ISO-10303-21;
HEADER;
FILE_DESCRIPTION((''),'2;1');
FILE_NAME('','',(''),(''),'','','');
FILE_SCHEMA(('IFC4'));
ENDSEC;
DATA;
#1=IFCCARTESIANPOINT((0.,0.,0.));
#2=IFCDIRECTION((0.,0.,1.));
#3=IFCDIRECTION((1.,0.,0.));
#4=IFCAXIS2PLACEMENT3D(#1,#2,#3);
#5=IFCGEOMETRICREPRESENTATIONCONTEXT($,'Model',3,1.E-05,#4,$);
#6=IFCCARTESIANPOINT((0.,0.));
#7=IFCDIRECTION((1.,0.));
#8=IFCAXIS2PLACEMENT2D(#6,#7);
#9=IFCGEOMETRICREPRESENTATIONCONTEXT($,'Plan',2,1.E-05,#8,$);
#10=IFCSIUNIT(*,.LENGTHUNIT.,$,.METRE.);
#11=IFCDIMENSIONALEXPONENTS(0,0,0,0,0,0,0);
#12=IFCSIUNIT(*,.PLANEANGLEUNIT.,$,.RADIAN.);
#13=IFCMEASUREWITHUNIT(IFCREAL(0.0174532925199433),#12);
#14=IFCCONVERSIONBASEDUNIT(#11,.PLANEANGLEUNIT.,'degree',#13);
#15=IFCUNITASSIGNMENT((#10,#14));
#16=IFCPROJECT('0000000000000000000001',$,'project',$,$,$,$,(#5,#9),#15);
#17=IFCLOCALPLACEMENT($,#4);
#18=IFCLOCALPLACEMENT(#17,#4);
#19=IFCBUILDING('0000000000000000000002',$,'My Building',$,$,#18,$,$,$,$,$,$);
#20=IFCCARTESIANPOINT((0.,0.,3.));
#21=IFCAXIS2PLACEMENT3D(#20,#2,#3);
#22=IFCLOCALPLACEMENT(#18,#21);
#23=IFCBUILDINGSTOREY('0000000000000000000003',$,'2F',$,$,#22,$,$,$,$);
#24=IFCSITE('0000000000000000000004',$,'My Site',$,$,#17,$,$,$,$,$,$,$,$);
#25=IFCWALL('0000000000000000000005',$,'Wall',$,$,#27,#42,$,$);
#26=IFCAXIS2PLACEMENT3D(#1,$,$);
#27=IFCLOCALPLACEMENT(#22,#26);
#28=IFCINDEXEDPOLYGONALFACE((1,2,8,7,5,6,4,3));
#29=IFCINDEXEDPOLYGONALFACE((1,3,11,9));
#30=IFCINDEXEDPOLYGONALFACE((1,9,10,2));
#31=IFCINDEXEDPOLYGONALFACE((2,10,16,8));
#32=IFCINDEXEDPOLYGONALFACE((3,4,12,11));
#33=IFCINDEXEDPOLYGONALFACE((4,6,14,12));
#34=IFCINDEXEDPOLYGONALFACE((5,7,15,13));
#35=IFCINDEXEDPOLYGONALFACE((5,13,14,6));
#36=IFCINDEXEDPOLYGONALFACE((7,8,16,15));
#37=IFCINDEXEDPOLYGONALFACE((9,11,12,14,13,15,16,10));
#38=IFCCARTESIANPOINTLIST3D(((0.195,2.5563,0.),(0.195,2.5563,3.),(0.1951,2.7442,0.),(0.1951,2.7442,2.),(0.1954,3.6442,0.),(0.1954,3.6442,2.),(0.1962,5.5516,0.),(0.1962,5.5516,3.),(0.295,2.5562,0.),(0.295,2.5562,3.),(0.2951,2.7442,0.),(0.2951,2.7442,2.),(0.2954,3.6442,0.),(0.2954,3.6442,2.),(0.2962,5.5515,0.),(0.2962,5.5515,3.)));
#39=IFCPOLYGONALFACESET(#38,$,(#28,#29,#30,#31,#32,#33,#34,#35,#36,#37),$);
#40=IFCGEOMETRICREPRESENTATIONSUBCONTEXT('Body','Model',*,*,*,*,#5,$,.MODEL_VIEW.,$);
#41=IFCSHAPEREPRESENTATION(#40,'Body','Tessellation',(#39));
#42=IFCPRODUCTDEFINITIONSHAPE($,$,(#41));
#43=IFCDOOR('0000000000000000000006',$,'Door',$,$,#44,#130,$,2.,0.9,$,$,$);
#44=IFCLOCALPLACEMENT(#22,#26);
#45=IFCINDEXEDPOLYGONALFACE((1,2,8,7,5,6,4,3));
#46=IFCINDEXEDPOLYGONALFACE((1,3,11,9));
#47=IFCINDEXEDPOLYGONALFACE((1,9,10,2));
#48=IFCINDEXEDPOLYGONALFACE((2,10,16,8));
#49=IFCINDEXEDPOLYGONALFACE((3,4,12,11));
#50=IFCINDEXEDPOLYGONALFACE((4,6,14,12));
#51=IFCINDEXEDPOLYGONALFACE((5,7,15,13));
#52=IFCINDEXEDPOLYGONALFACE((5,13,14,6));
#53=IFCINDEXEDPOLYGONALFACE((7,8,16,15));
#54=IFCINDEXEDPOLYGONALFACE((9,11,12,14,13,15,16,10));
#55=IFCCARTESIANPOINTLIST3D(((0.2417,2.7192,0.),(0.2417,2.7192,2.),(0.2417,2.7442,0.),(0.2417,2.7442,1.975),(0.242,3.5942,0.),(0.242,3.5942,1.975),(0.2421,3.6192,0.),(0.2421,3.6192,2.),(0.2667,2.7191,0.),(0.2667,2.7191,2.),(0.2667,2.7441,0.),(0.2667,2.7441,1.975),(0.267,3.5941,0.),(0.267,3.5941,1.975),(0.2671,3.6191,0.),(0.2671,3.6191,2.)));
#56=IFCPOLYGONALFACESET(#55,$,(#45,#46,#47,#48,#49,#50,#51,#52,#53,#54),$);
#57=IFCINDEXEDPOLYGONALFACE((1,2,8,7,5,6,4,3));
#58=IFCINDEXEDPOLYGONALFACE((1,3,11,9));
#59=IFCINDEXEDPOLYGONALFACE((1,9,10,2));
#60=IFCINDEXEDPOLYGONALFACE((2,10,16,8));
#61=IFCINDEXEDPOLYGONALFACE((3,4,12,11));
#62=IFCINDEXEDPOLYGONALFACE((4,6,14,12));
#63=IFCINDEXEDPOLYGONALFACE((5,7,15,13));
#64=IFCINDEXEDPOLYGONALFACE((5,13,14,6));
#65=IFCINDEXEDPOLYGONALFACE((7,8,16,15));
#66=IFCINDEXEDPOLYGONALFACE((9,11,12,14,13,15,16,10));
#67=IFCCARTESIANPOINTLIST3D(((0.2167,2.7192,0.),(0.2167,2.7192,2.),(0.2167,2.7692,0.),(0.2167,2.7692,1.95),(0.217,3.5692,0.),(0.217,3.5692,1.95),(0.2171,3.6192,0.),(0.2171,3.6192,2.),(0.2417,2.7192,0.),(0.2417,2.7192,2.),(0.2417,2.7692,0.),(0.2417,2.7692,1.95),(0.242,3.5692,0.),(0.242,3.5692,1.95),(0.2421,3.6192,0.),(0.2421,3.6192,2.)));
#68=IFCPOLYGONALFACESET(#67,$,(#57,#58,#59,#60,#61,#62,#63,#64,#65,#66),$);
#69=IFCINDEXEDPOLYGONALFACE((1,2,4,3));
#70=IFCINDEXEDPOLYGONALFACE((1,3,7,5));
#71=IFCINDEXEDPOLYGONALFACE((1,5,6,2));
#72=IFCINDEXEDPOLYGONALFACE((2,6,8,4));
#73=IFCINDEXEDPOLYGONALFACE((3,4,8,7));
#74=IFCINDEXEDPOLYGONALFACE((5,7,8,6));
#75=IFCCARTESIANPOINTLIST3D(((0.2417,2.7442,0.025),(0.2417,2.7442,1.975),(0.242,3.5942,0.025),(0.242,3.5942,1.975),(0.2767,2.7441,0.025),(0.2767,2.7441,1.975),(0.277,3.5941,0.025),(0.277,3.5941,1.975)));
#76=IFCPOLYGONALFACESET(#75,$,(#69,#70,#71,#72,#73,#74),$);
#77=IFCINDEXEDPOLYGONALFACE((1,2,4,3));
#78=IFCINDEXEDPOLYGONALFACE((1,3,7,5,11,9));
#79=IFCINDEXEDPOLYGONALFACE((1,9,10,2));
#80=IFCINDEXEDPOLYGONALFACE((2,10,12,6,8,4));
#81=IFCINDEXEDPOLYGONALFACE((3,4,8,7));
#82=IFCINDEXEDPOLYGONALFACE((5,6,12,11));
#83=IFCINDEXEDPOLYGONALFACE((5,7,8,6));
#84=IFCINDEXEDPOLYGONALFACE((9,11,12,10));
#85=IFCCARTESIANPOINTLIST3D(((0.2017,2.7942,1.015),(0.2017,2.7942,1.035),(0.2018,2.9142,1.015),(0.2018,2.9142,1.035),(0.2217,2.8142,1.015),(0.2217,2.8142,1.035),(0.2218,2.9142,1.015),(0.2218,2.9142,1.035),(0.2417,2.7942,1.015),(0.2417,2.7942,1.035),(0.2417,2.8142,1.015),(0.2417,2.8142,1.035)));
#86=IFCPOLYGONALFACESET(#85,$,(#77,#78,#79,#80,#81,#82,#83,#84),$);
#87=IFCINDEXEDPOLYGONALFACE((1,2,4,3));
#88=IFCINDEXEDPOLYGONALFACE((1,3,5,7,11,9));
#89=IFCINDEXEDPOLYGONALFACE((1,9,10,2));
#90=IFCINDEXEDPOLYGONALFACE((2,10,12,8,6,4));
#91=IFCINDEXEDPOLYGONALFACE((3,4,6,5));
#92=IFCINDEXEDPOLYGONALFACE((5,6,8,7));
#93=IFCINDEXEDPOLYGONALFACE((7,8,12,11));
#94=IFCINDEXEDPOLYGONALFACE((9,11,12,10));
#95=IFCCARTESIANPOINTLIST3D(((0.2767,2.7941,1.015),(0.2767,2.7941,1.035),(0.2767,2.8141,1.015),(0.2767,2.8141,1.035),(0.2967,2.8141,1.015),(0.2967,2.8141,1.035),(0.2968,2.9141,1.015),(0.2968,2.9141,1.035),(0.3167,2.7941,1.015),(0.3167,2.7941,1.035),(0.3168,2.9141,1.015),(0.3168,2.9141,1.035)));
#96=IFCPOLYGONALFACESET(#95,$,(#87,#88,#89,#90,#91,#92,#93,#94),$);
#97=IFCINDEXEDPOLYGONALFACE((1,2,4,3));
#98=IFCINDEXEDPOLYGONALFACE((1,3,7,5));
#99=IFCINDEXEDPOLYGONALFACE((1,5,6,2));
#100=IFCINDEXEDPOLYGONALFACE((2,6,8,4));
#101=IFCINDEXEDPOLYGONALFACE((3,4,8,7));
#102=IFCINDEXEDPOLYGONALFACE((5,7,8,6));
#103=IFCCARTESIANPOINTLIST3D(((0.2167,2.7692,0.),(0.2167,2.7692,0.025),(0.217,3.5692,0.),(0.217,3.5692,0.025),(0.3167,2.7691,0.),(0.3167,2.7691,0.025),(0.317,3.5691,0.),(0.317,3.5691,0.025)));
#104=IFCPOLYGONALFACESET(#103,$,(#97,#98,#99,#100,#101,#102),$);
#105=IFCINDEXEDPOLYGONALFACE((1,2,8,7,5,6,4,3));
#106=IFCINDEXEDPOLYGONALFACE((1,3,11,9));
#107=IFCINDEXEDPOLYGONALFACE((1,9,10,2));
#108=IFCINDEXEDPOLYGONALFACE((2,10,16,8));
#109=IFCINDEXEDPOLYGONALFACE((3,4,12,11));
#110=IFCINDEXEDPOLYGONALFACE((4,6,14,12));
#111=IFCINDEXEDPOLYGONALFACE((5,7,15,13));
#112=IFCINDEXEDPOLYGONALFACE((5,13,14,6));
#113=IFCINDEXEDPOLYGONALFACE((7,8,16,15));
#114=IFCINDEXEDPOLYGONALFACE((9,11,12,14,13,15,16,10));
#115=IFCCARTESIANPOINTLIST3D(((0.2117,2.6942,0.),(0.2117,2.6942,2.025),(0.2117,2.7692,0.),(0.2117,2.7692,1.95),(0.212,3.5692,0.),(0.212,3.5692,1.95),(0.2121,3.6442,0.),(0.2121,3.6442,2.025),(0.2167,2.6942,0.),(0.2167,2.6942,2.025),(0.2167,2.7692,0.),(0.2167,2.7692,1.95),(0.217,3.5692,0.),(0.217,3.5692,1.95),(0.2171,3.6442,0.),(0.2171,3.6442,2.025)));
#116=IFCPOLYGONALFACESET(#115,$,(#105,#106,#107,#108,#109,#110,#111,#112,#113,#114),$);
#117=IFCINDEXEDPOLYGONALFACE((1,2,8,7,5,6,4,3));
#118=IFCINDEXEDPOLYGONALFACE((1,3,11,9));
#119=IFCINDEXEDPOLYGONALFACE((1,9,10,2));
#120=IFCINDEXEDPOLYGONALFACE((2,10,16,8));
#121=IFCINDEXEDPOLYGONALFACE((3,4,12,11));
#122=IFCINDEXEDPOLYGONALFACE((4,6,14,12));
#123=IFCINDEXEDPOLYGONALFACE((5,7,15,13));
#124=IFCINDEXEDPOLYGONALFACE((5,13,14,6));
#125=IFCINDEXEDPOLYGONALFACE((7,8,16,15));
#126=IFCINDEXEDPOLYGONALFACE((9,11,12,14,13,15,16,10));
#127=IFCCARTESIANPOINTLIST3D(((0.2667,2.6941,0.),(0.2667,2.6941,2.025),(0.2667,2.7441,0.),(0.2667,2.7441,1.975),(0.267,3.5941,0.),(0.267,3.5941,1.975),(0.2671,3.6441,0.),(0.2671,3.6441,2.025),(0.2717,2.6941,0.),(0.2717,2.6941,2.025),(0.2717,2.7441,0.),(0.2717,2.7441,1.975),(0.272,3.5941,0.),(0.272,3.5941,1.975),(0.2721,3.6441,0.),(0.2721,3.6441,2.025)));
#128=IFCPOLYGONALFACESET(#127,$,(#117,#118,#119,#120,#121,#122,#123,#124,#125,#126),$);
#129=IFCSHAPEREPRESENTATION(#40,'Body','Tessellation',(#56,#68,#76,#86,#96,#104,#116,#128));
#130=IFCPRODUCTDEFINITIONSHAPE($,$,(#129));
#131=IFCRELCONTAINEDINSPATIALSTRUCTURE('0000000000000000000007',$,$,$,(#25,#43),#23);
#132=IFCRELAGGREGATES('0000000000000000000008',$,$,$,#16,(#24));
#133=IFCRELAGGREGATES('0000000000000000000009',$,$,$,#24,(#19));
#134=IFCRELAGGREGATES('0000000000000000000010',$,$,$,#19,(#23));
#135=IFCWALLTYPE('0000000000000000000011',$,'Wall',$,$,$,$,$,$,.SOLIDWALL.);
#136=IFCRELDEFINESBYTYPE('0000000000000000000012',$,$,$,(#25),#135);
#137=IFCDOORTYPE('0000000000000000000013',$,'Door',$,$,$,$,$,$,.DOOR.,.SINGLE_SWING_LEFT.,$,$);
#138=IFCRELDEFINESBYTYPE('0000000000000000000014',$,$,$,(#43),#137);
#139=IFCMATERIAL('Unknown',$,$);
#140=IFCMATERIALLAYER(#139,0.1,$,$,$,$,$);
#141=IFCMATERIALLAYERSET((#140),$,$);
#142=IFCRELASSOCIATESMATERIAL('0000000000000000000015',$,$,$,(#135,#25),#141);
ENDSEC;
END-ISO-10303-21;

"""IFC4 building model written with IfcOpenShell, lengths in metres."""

from ifc_helpers import new_model, entity, si_unit, converted_unit, frame, origin_with_axes, origin_2d_with_axis, place, context, subcontext, project, spatial, line, indexed_curve, outline, extrude, shape, source, transform, mapped, material, layer, layer_set, layer_usage, type_object, type_shapes, element, fill, save


model = new_model("IFC4")

# Units and contexts
model_context = context("Model", 3, precision=1e-05, world=origin_with_axes())
plan_context = context("Plan", 2, precision=1e-05, world=origin_2d_with_axis())
body_context_1 = subcontext(model_context, "Body", "Model", "MODEL_VIEW")
body_context_2 = subcontext(plan_context, "Body", "Plan", "PLAN_VIEW")
ifc_project = project(units=[si_unit("LENGTHUNIT", "METRE"), converted_unit("PLANEANGLEUNIT", "degree", entity("IfcReal", 0.0174532925199433), si_unit("PLANEANGLEUNIT", "RADIAN"), dimensions=[0, 0, 0, 0, 0, 0, 0])], contexts=[model_context, plan_context])

# Site, building, storey
site_placement = place(None, origin_with_axes())
site = spatial("IfcSite", under=ifc_project, at=site_placement, Name="My Site")
building_placement = place(site_placement, origin_with_axes())
building = spatial("IfcBuilding", under=site, at=building_placement, Name="My Building")
storey_placement = place(building_placement, frame((0.0, 0.0, 3.0), z_axis=(0.0, 0.0, 1.0), x_axis=(1.0, 0.0, 0.0)))
storey = spatial("IfcBuildingStorey", under=building, at=storey_placement, Name="2F")

# Shared definitions
ifc_material = material(Name="Unknown")

# Shared definitions
ifc_layer_1 = layer(ifc_material, 0.1)
ifc_layer_set_1 = layer_set([ifc_layer_1])
wall_type = type_object("IfcWallType", Name="Wall", PredefinedType="SOLIDWALL", material=ifc_layer_set_1)

# Wall, opening, door
ifc_layer_usage_1 = layer_usage(ifc_layer_set_1, "AXIS2", "POSITIVE", 0.0)
wall_1_placement = place(storey_placement, frame((0.1962, 5.5516, 0.0), z_axis=(0.0, 0.0, 1.0), x_axis=(-0.000399, -1.0, 0.0)))
wall_1 = element("IfcWall", 1, at=wall_1_placement, inside=storey, type_object=wall_type, material=ifc_layer_usage_1, Name="Wall", context=body_context_1, shape_type="SweptSolid", body=[
    extrude(outline(indexed_curve([(0.0, 0.0), (0.0, 0.1), (2.9953, 0.1), (2.9953, 0.0)], segments=[line(1, 2, 3, 4, 1)])), origin_with_axes(), (0.0, 0.0, 1.0), 3.0),
])
shared_shape_1 = source(origin_with_axes(), body_context_1, "Body", "SweptSolid", [
    extrude(outline(indexed_curve([(0.0, 0.0), (0.9, 0.0), (0.9, 2.0), (0.0, 2.0)], segments=[line(1, 2, 3, 4, 1)])), frame((0.0, -0.6, 0.0), z_axis=(0.0, -1.0, 0.0), x_axis=(1.0, 0.0, 0.0)), (0.0, 0.0, -1.0), 1.2),
])
opening_1_placement = place(wall_1_placement, frame((1.9074, 0.0, 0.0), z_axis=(0.0, 0.0, 1.0), x_axis=(1.0, 0.0, 0.0)))
opening_1 = element("IfcOpeningElement", 2, at=opening_1_placement, cuts=wall_1, PredefinedType="OPENING", context=body_context_1, shape_type="MappedRepresentation", body=[
    mapped(shared_shape_1, transform((0.0, 0.0, 0.0), x_axis=(1.0, 0.0, 0.0), y_axis=(0.0, 1.0, 0.0), z_axis=(0.0, 0.0, 1.0), scale=1.0)),
])
door_type_1 = type_object("IfcDoorType", Name="Door", OperationType="SINGLE_SWING_LEFT", PredefinedType="DOOR")
shared_shape_2 = source(origin_with_axes(), body_context_1, "Body", "SweptSolid", [
    extrude(outline(indexed_curve([(0.0, 0.0), (0.0, 2.0), (0.9, 2.0), (0.9, 0.0), (0.875, 0.0), (0.875, 1.975), (0.025, 1.975), (0.025, 0.0)], segments=[line(1, 2, 3, 4, 5, 6, 7, 8, 1)])), frame((0.0, 0.025, 0.0), z_axis=(0.0, -1.0, 0.0), x_axis=(1.0, 0.0, 0.0)), (0.0, 0.0, -1.0), 0.025),
    extrude(outline(indexed_curve([(0.0, 0.0), (0.0, 2.0), (0.9, 2.0), (0.9, 0.0), (0.85, 0.0), (0.85, 1.95), (0.05, 1.95), (0.05, 0.0)], segments=[line(1, 2, 3, 4, 5, 6, 7, 8, 1)])), frame((0.0, 0.0, 0.0), z_axis=(0.0, -1.0, 0.0), x_axis=(1.0, 0.0, 0.0)), (0.0, 0.0, -1.0), 0.025),
    extrude(outline(indexed_curve([(0.0, 0.0), (0.85, 0.0), (0.85, 0.035), (0.0, 0.035)], segments=[line(1, 2, 3, 4, 1)])), frame((0.025, 0.025, 0.025), z_axis=(0.0, 0.0, 1.0), x_axis=(1.0, 0.0, 0.0)), (0.0, 0.0, 1.0), 1.95),
    extrude(outline(indexed_curve([(0.0, 0.0), (0.0, -0.04), (-0.12, -0.04), (-0.12, -0.02), (-0.02, -0.02), (-0.02, 0.0)], segments=[line(1, 2, 3, 4, 5, 6, 1)])), frame((0.825, 0.025, 1.015), z_axis=(0.0, 0.0, 1.0), x_axis=(1.0, 0.0, 0.0)), (0.0, 0.0, 1.0), 0.02),
    extrude(outline(indexed_curve([(0.0, 0.0), (0.0, 0.04), (-0.12, 0.04), (-0.12, 0.02), (-0.02, 0.02), (-0.02, 0.0)], segments=[line(1, 2, 3, 4, 5, 6, 1)])), frame((0.825, 0.06, 1.015), z_axis=(0.0, 0.0, 1.0), x_axis=(1.0, 0.0, 0.0)), (0.0, 0.0, 1.0), 0.02),
    extrude(outline(indexed_curve([(0.0, 0.0), (0.8, 0.0), (0.8, 0.1), (0.0, 0.1)], segments=[line(1, 2, 3, 4, 1)])), frame((0.05, 0.0, 0.0), z_axis=(0.0, 0.0, 1.0), x_axis=(1.0, 0.0, 0.0)), (0.0, 0.0, 1.0), 0.025),
    extrude(outline(indexed_curve([(0.0, 0.0), (0.0, 2.025), (0.95, 2.025), (0.95, 0.0), (0.875, 0.0), (0.875, 1.95), (0.075, 1.95), (0.075, 0.0)], segments=[line(1, 2, 3, 4, 5, 6, 7, 8, 1)])), frame((-0.025, -0.005, 0.0), z_axis=(0.0, -1.0, 0.0), x_axis=(1.0, 0.0, 0.0)), (0.0, 0.0, -1.0), 0.005),
    extrude(outline(indexed_curve([(0.0, 0.0), (0.0, 2.025), (0.95, 2.025), (0.95, 0.0), (0.9, 0.0), (0.9, 1.975), (0.05, 1.975), (0.05, 0.0)], segments=[line(1, 2, 3, 4, 5, 6, 7, 8, 1)])), frame((-0.025, 0.05, 0.0), z_axis=(0.0, -1.0, 0.0), x_axis=(1.0, 0.0, 0.0)), (0.0, 0.0, -1.0), 0.005),
])
shared_shape_3 = source(origin_with_axes(), body_context_2, "Body", "Curve2D", [
    entity("IfcIndexedPolyCurve", entity("IfcCartesianPointList2D", [[0.0, 0.0], [0.0, 0.05], [0.025, 0.05], [0.025, 0.025], [0.05, 0.025], [0.05, 0.0]]), [entity("IfcLineIndex", [1, 2, 3, 4, 5, 6, 1])]),
    entity("IfcIndexedPolyCurve", entity("IfcCartesianPointList2D", [[0.9, 0.0], [0.9, 0.05], [0.875, 0.05], [0.875, 0.025], [0.85, 0.025], [0.85, 0.0]]), [entity("IfcLineIndex", [1, 2, 3, 4, 5, 6, 1])]),
    entity("IfcTrimmedCurve", entity("IfcEllipse", entity("IfcAxis2Placement2D", entity("IfcCartesianPoint", [0.06, 0.05]), entity("IfcDirection", [1.0, 0.0])), 0.815, 0.85), [entity("IfcCartesianPoint", [0.875, 0.05])], [entity("IfcCartesianPoint", [0.06, 0.9])], True, "CARTESIAN"),
    entity("IfcIndexedPolyCurve", entity("IfcCartesianPointList2D", [[0.025, 0.05], [0.06, 0.05], [0.06, 0.9], [0.025, 0.9]]), [entity("IfcLineIndex", [1, 2, 3, 4, 1])]),
])
type_shapes(door_type_1, [shared_shape_2, shared_shape_3])
door_1_placement = place(opening_1_placement, frame((0.025, 0.0216, 0.0), z_axis=(0.0, 0.0, 1.0), x_axis=(1.0, 0.0, 0.0)))
door_1 = element("IfcDoor", 3, at=door_1_placement, inside=storey, type_object=door_type_1, Name="Door", OverallHeight=2.0, OverallWidth=0.9, shapes=[
    shape(body_context_1, "Body", "MappedRepresentation", [mapped(shared_shape_2, transform((0.0, 0.0, 0.0), x_axis=(1.0, 0.0, 0.0), y_axis=(0.0, 1.0, 0.0), z_axis=(0.0, 0.0, 1.0), scale=1.0))]),
    shape(body_context_2, "Body", "MappedRepresentation", [mapped(shared_shape_3, transform((0.0, 0.0, 0.0), x_axis=(1.0, 0.0, 0.0), y_axis=(0.0, 1.0, 0.0), z_axis=(0.0, 0.0, 1.0), scale=1.0))]),
])
fill(opening_1, door_1)

save(model, "model.ifc")
